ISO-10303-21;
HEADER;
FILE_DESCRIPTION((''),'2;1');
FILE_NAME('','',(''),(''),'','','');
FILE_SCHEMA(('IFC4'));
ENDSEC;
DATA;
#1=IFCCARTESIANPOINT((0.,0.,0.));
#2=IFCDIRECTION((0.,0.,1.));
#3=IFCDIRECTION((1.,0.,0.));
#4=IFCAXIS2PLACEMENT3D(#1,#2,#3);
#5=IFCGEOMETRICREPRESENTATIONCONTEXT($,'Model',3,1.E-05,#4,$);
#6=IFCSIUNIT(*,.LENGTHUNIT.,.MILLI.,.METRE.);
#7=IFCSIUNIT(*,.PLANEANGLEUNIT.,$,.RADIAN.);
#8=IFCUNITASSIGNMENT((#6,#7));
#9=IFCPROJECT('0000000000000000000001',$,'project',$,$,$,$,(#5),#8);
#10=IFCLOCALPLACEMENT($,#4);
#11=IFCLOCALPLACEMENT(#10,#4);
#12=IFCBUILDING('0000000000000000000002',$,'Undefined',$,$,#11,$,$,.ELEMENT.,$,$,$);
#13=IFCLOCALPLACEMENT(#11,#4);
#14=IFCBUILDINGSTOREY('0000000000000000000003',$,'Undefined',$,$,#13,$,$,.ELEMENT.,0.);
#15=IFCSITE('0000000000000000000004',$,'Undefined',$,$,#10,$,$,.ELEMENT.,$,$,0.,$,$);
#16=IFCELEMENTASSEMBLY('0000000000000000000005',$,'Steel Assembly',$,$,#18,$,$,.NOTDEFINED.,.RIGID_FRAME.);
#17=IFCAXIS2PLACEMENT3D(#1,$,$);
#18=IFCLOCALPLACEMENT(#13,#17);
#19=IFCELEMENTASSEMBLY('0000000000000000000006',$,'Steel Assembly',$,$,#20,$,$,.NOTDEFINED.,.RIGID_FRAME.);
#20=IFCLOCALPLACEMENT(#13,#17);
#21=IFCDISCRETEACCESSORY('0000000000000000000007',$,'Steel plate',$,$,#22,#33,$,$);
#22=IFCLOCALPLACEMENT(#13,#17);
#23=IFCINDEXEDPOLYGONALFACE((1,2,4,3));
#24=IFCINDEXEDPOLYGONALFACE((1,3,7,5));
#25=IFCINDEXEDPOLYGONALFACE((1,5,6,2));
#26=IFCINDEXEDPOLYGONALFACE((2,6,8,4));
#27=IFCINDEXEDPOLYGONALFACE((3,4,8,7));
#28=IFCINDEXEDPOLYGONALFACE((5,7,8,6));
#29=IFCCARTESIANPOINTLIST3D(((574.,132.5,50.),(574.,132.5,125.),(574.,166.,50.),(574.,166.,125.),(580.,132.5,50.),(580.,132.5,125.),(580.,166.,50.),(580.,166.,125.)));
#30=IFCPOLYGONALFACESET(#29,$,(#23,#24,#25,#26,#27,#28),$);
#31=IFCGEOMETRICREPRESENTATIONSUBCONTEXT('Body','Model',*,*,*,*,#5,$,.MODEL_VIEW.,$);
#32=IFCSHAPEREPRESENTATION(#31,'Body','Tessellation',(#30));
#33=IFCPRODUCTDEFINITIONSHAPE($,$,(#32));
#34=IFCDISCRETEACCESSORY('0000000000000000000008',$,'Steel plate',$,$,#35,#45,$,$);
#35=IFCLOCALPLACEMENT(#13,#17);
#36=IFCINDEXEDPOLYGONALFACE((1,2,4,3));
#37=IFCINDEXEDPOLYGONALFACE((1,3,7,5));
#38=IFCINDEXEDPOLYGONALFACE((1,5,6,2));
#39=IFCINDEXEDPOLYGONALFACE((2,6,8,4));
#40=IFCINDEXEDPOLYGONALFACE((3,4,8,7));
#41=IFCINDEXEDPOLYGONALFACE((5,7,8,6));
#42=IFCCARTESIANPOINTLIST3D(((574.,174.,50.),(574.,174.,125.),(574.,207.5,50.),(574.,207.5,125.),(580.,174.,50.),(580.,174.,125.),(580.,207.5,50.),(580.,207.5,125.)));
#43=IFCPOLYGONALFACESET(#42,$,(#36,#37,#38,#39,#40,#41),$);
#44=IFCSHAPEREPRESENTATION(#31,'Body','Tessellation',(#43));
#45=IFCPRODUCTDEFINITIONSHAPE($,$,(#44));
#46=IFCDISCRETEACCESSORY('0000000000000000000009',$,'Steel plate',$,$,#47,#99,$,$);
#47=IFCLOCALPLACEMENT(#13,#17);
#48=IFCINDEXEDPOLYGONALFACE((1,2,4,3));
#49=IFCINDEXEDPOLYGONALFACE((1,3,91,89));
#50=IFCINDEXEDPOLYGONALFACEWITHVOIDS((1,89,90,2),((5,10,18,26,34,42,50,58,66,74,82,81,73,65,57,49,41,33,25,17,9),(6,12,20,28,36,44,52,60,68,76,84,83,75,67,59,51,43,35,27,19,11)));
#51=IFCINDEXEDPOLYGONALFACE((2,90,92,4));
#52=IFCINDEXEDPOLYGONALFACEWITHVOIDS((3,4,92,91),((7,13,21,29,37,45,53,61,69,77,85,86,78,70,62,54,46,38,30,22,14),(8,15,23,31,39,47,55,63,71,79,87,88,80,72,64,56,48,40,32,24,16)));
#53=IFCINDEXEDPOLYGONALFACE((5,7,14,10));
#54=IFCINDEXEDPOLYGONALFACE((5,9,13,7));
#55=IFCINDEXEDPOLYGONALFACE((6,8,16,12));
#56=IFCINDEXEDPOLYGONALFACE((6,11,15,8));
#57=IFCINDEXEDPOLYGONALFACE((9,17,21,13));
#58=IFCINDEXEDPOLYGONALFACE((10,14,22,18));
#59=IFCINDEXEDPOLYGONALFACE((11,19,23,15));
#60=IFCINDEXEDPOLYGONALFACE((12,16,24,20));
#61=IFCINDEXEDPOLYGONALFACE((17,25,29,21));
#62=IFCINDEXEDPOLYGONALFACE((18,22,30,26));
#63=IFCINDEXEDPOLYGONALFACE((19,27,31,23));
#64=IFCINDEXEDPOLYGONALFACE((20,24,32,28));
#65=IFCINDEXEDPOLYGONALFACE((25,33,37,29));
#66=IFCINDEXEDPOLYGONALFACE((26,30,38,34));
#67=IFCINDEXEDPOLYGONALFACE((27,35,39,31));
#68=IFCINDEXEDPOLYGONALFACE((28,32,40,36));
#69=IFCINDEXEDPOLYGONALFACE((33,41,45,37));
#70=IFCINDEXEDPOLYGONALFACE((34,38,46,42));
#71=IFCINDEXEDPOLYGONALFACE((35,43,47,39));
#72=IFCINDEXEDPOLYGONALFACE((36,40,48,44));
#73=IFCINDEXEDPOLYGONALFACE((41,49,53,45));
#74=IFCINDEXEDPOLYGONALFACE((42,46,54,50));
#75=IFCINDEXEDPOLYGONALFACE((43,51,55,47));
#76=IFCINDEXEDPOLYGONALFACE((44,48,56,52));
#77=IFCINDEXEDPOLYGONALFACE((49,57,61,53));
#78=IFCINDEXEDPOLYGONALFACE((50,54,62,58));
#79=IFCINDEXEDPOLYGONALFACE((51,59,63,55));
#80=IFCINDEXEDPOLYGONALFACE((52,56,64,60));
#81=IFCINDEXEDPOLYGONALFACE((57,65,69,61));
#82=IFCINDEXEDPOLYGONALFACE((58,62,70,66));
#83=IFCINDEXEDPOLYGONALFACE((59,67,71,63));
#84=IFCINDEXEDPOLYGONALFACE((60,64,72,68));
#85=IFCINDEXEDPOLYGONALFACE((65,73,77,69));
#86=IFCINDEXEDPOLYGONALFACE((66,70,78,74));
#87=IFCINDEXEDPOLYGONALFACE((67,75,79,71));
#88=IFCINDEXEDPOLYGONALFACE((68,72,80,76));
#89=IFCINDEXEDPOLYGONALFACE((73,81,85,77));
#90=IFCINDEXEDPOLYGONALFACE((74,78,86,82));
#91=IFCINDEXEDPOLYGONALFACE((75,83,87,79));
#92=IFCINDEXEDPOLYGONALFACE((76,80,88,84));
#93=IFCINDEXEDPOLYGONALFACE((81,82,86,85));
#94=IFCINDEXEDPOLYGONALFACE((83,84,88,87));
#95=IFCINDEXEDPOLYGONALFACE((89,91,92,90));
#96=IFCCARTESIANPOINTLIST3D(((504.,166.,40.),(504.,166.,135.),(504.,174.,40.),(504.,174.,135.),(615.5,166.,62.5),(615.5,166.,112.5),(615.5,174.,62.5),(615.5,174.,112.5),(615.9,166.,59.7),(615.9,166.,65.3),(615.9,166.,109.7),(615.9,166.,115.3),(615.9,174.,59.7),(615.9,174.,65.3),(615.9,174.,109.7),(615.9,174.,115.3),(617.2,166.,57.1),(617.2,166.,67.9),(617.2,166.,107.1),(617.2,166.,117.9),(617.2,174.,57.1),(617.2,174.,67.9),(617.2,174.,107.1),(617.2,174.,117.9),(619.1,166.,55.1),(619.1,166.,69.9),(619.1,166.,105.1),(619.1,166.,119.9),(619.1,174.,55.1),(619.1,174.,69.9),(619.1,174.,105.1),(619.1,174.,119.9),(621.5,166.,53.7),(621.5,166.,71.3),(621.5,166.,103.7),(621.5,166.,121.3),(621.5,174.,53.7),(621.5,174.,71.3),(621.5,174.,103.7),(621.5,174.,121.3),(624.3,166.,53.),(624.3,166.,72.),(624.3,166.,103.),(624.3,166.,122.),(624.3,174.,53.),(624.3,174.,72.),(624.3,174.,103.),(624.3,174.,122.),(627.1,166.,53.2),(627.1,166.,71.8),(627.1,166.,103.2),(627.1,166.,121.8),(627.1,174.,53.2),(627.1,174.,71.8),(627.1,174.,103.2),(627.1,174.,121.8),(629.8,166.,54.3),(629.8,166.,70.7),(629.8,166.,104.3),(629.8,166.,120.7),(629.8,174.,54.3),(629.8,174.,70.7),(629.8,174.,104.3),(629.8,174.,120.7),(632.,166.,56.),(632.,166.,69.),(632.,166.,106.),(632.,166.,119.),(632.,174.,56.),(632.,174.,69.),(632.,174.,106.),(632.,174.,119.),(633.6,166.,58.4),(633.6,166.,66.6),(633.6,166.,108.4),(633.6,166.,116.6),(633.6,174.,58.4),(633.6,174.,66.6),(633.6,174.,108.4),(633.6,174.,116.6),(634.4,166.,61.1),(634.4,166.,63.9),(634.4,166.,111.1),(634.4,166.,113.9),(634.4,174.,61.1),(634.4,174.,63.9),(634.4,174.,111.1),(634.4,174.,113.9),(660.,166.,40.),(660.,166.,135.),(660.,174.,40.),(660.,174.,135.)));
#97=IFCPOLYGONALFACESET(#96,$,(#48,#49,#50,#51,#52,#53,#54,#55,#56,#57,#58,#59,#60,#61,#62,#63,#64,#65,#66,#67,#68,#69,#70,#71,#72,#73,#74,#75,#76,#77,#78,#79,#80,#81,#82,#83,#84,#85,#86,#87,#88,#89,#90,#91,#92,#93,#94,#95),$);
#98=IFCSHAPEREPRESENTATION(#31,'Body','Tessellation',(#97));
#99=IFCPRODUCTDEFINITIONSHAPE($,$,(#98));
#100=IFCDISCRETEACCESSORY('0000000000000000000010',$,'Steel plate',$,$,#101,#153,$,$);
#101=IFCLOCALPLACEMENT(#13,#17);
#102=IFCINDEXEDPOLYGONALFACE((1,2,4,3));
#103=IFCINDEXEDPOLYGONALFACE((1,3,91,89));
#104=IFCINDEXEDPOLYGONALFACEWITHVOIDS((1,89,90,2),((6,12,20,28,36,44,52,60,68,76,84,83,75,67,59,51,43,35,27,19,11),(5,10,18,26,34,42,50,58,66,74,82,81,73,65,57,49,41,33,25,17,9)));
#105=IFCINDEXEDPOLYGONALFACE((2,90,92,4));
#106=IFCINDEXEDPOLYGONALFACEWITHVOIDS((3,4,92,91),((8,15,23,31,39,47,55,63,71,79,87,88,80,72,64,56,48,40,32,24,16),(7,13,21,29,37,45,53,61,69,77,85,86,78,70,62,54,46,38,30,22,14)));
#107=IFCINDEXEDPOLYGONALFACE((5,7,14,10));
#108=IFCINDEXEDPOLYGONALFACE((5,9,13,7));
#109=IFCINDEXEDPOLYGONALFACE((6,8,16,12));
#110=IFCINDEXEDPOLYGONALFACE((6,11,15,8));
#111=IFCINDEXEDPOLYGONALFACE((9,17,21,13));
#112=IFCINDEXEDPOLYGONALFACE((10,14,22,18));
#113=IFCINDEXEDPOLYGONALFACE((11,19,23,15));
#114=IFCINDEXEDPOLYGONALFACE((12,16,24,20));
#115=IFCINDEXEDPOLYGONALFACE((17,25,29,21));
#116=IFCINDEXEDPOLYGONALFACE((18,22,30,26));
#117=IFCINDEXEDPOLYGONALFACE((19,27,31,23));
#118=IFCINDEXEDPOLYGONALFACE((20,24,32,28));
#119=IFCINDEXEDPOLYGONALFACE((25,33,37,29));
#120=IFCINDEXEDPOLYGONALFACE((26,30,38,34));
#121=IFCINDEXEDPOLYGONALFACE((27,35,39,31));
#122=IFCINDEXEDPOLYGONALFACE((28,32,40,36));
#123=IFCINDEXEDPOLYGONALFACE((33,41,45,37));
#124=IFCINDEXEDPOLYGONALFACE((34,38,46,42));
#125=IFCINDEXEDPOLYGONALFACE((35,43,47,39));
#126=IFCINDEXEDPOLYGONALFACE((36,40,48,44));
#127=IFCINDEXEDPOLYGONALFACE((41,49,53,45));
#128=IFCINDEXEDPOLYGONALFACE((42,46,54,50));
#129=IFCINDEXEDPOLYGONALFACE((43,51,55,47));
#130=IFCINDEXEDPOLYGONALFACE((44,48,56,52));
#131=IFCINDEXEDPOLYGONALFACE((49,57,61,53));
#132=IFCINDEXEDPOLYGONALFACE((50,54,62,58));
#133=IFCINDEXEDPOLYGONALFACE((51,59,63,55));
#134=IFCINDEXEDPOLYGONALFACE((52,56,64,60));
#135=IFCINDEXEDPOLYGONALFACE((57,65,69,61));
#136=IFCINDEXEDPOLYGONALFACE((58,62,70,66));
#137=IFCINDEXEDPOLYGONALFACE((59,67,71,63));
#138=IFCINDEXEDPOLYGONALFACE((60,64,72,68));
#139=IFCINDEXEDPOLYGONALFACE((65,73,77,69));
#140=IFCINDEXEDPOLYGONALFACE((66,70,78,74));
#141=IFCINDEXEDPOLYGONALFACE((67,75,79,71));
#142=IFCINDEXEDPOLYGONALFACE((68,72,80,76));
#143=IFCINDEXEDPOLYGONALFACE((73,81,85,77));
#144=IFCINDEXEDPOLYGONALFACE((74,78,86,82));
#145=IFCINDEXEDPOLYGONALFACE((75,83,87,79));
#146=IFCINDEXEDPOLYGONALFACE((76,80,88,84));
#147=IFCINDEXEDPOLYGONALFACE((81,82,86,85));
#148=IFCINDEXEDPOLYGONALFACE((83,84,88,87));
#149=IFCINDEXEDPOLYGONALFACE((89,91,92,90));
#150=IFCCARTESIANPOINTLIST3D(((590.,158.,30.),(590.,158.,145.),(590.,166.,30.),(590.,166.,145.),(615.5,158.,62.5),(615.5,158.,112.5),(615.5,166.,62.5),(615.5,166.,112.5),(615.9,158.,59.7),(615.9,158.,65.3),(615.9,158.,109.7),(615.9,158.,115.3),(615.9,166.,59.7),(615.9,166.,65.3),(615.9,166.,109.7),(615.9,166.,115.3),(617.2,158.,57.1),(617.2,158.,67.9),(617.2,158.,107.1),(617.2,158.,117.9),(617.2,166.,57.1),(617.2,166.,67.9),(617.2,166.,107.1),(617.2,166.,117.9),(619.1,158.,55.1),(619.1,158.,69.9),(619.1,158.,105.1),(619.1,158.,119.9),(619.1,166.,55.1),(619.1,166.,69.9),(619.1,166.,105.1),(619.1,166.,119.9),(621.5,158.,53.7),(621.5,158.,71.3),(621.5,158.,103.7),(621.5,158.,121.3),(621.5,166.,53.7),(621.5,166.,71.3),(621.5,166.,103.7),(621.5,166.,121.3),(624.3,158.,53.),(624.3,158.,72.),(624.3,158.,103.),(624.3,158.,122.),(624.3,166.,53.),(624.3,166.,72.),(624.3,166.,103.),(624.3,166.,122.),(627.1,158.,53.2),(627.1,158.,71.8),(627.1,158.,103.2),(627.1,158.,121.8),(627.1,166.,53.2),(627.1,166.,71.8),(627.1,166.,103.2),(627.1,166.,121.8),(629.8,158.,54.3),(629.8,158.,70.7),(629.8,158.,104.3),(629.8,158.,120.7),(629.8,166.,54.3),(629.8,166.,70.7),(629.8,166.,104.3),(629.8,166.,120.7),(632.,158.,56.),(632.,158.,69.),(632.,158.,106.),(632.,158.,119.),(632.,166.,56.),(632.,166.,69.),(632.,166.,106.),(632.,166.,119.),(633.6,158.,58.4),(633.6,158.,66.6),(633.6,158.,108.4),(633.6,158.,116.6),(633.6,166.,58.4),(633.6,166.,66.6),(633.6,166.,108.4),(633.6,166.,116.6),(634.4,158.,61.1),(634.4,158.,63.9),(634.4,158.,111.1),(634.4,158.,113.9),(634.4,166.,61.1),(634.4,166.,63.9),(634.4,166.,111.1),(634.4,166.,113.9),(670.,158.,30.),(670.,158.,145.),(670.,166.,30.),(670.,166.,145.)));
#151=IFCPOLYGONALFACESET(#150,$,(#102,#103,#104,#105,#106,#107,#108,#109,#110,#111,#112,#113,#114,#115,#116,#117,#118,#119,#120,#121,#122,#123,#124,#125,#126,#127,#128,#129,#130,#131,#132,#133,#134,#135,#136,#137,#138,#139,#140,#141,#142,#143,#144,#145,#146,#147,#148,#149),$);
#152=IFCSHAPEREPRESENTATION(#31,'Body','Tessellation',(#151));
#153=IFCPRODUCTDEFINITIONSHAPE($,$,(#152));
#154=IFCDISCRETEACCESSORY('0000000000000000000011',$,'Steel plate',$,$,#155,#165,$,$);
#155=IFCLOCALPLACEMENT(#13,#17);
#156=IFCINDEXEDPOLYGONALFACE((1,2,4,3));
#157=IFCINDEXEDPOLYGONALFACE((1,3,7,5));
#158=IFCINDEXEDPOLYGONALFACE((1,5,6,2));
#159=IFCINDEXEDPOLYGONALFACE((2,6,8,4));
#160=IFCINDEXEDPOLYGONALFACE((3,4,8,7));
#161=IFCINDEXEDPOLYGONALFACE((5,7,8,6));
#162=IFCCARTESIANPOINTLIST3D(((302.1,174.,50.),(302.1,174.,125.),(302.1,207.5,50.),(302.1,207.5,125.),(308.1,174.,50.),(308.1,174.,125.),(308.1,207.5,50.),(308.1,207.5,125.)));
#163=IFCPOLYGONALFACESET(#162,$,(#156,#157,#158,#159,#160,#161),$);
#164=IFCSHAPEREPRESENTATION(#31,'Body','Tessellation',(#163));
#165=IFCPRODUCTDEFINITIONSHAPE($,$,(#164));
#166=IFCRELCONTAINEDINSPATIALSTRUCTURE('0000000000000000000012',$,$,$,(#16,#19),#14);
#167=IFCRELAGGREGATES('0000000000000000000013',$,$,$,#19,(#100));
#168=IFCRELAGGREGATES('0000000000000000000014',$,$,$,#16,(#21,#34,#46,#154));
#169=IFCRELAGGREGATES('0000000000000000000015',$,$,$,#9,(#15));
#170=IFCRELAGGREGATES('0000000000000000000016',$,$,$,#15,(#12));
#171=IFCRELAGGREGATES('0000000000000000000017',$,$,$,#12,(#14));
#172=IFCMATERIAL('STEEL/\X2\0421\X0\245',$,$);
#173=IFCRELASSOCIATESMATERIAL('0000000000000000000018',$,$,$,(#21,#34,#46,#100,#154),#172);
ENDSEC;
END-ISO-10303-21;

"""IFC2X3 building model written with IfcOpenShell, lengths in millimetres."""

from ifc_helpers import new_model, si_unit, frame, origin_with_axes, origin_2d_with_axis, place, context, subcontext, project, spatial, polyline, circle, outline, extrude, source, transform, mapped, material, element, aggregate, save


model = new_model("IFC2X3")

# Units and contexts
model_context = context("Model", 3, precision=1e-05, world=origin_with_axes())
body_context = subcontext(model_context, "Body", "Model", "MODEL_VIEW")
ifc_project = project(units=[si_unit("LENGTHUNIT", "METRE", prefix="MILLI"), si_unit("PLANEANGLEUNIT", "RADIAN")], contexts=[model_context])

# Site, building, storey
site_placement = place(None, origin_with_axes())
site = spatial("IfcSite", under=ifc_project, at=site_placement, Name="Undefined", CompositionType="ELEMENT", RefElevation=0.0)
building_placement = place(site_placement, origin_with_axes())
building = spatial("IfcBuilding", under=site, at=building_placement, Name="Undefined", CompositionType="ELEMENT")
storey_placement = place(building_placement, origin_with_axes())
storey = spatial("IfcBuildingStorey", under=building, at=storey_placement, Name="Undefined", CompositionType="ELEMENT", Elevation=0.0)

# Element assembly
assembly_1_placement = place(storey_placement, origin_with_axes())
assembly_1 = element("IfcElementAssembly", 1, at=assembly_1_placement, inside=storey, Name="Steel Assembly", AssemblyPlace="NOTDEFINED", PredefinedType="RIGID_FRAME")
ifc_material_1 = material(Name="STEEL/С245")

# Element assembly
assembly_2_placement = place(storey_placement, origin_with_axes())
assembly_2 = element("IfcElementAssembly", 2, at=assembly_2_placement, inside=storey, Name="Steel Assembly", AssemblyPlace="NOTDEFINED", PredefinedType="RIGID_FRAME")

# Discrete accessories, openings
discrete_accessory_1_placement = place(assembly_1_placement, frame((577.0, 132.5, 125.0), z_axis=(1.0, 0.0, 0.0), x_axis=(0.0, 0.0, -1.0)))
discrete_accessory_1 = element("IfcDiscreteAccessory", 3, at=discrete_accessory_1_placement, material=ifc_material_1, Name="Steel plate", context=body_context, shape_type="SweptSolid", body=[
    extrude(outline(polyline([(0.0, 0.0), (75.0, 0.0), (75.0, 75.0), (0.0, 75.0), (0.0, 0.0)])), frame((0.0, 0.0, -3.0), z_axis=(0.0, 0.0, 1.0), x_axis=(1.0, 0.0, 0.0)), (0.0, 0.0, 1.0), 6.0),
])
opening_1_placement = place(assembly_1_placement, frame((577.0, 132.5, 125.0), z_axis=(1.0, 0.0, 0.0), x_axis=(0.0, 0.0, -1.0)))
element("IfcOpeningElement", 4, at=opening_1_placement, cuts=discrete_accessory_1, ObjectType="Recess", context=body_context, shape_type="SweptSolid", body=[
    extrude(outline(polyline([(0.0, 0.0), (75.0, 0.0), (75.0, 150.0), (0.0, 150.0), (0.0, 0.0)])), frame((112.5, 108.5, 6.0), z_axis=(0.0, 0.0, -1.0), x_axis=(0.0, -1.0, 0.0)), (0.0, 0.0, 1.0), 12.0),
])
discrete_accessory_2_placement = place(assembly_1_placement, frame((577.0, 207.5, 50.0), z_axis=(1.0, 0.0, 0.0), x_axis=(0.0, 0.0, 1.0)))
discrete_accessory_2 = element("IfcDiscreteAccessory", 5, at=discrete_accessory_2_placement, material=ifc_material_1, Name="Steel plate", context=body_context, shape_type="SweptSolid", body=[
    extrude(outline(polyline([(0.0, 0.0), (75.0, 0.0), (75.0, 75.0), (0.0, 75.0), (0.0, 0.0)])), frame((0.0, 0.0, -3.0), z_axis=(0.0, 0.0, 1.0), x_axis=(1.0, 0.0, 0.0)), (0.0, 0.0, 1.0), 6.0),
])
opening_2_placement = place(assembly_1_placement, frame((577.0, 207.5, 50.0), z_axis=(1.0, 0.0, 0.0), x_axis=(0.0, 0.0, 1.0)))
element("IfcOpeningElement", 6, at=opening_2_placement, cuts=discrete_accessory_2, ObjectType="Recess", context=body_context, shape_type="SweptSolid", body=[
    extrude(outline(polyline([(0.0, 0.0), (75.0, 0.0), (75.0, 150.0), (0.0, 150.0), (0.0, 0.0)])), frame((112.5, 108.5, 6.0), z_axis=(0.0, 0.0, -1.0), x_axis=(0.0, -1.0, 0.0)), (0.0, 0.0, 1.0), 12.0),
])
discrete_accessory_3_placement = place(assembly_1_placement, frame((660.0, 170.0, 40.0), z_axis=(0.0, -1.0, 0.0), x_axis=(0.0, 0.0, 1.0)))
discrete_accessory_3 = element("IfcDiscreteAccessory", 7, at=discrete_accessory_3_placement, material=ifc_material_1, Name="Steel plate", context=body_context, shape_type="SweptSolid", body=[
    extrude(outline(polyline([(0.0, 0.0), (95.0, 0.0), (95.0, 156.0), (0.0, 156.0), (0.0, 0.0)])), frame((0.0, 0.0, -4.0), z_axis=(0.0, 0.0, 1.0), x_axis=(1.0, 0.0, 0.0)), (0.0, 0.0, 1.0), 8.0),
])
shared_shape_1 = source(origin_with_axes(), body_context, "Body", "SweptSolid", [
    extrude(circle(Radius=9.5, at=origin_2d_with_axis()), frame((0.0, -4.1, 0.0), z_axis=(0.0, 1.0, 0.0), x_axis=(1.0, 0.0, 0.0)), (0.0, 0.0, 1.0), 12.3),
])
opening_3_placement = place(assembly_1_placement, frame((625.0, 170.0, 87.5), z_axis=(0.0, 0.0, 1.0), x_axis=(-1.0, 0.0, 0.0)))
element("IfcOpeningElement", 8, at=opening_3_placement, cuts=discrete_accessory_3, ObjectType="Opening", context=body_context, shape_type="MappedRepresentation", body=[
    mapped(shared_shape_1, transform((0.0, 0.0, -25.0))),
    mapped(shared_shape_1, transform((0.0, 0.0, 25.0))),
])
discrete_accessory_4_placement = place(assembly_2_placement, frame((670.0, 162.0, 30.0), z_axis=(0.0, 1.0, 0.0), x_axis=(-1.0, 0.0, 0.0)))
discrete_accessory_4 = element("IfcDiscreteAccessory", 9, at=discrete_accessory_4_placement, material=ifc_material_1, Name="Steel plate", context=body_context, shape_type="SweptSolid", body=[
    extrude(outline(polyline([(0.0, 0.0), (80.0, 0.0), (80.0, 115.0), (0.0, 115.0), (0.0, 0.0)])), frame((0.0, 0.0, -4.0), z_axis=(0.0, 0.0, 1.0), x_axis=(1.0, 0.0, 0.0)), (0.0, 0.0, 1.0), 8.0),
])
shared_shape_2 = source(origin_with_axes(), body_context, "Body", "SweptSolid", [
    extrude(circle(Radius=9.5, at=origin_2d_with_axis()), frame((0.0, 3.9, 0.0), z_axis=(0.0, 1.0, 0.0), x_axis=(1.0, 0.0, 0.0)), (0.0, 0.0, 1.0), 12.1),
])
opening_4_placement = place(assembly_2_placement, frame((625.0, 170.0, 87.5), z_axis=(0.0, 0.0, 1.0), x_axis=(-1.0, 0.0, 0.0)))
element("IfcOpeningElement", 10, at=opening_4_placement, cuts=discrete_accessory_4, ObjectType="Opening", context=body_context, shape_type="MappedRepresentation", body=[
    mapped(shared_shape_2, transform((0.0, 0.0, -25.0))),
    mapped(shared_shape_2, transform((0.0, 0.0, 25.0))),
])
aggregate(assembly_2, [discrete_accessory_4])
discrete_accessory_5_placement = place(assembly_1_placement, frame((305.1, 207.5, 125.0), z_axis=(-1.0, 0.0, 0.0), x_axis=(0.0, 0.0, -1.0)))
discrete_accessory_5 = element("IfcDiscreteAccessory", 11, at=discrete_accessory_5_placement, material=ifc_material_1, Name="Steel plate", context=body_context, shape_type="SweptSolid", body=[
    extrude(outline(polyline([(0.0, 0.0), (75.0, 0.0), (75.0, 75.0), (0.0, 75.0), (0.0, 0.0)])), frame((0.0, 0.0, -3.0), z_axis=(0.0, 0.0, 1.0), x_axis=(1.0, 0.0, 0.0)), (0.0, 0.0, 1.0), 6.0),
])
opening_5_placement = place(assembly_1_placement, frame((305.1, 207.5, 125.0), z_axis=(-1.0, 0.0, 0.0), x_axis=(0.0, 0.0, -1.0)))
element("IfcOpeningElement", 12, at=opening_5_placement, cuts=discrete_accessory_5, ObjectType="Recess", context=body_context, shape_type="SweptSolid", body=[
    extrude(outline(polyline([(0.0, 0.0), (75.0, 0.0), (75.0, 150.0), (0.0, 150.0), (0.0, 0.0)])), frame((112.5, 108.5, 6.0), z_axis=(0.0, 0.0, -1.0), x_axis=(0.0, -1.0, 0.0)), (0.0, 0.0, 1.0), 12.0),
])
aggregate(assembly_1, [discrete_accessory_1, discrete_accessory_2, discrete_accessory_3, discrete_accessory_5])

save(model, "model.ifc")
